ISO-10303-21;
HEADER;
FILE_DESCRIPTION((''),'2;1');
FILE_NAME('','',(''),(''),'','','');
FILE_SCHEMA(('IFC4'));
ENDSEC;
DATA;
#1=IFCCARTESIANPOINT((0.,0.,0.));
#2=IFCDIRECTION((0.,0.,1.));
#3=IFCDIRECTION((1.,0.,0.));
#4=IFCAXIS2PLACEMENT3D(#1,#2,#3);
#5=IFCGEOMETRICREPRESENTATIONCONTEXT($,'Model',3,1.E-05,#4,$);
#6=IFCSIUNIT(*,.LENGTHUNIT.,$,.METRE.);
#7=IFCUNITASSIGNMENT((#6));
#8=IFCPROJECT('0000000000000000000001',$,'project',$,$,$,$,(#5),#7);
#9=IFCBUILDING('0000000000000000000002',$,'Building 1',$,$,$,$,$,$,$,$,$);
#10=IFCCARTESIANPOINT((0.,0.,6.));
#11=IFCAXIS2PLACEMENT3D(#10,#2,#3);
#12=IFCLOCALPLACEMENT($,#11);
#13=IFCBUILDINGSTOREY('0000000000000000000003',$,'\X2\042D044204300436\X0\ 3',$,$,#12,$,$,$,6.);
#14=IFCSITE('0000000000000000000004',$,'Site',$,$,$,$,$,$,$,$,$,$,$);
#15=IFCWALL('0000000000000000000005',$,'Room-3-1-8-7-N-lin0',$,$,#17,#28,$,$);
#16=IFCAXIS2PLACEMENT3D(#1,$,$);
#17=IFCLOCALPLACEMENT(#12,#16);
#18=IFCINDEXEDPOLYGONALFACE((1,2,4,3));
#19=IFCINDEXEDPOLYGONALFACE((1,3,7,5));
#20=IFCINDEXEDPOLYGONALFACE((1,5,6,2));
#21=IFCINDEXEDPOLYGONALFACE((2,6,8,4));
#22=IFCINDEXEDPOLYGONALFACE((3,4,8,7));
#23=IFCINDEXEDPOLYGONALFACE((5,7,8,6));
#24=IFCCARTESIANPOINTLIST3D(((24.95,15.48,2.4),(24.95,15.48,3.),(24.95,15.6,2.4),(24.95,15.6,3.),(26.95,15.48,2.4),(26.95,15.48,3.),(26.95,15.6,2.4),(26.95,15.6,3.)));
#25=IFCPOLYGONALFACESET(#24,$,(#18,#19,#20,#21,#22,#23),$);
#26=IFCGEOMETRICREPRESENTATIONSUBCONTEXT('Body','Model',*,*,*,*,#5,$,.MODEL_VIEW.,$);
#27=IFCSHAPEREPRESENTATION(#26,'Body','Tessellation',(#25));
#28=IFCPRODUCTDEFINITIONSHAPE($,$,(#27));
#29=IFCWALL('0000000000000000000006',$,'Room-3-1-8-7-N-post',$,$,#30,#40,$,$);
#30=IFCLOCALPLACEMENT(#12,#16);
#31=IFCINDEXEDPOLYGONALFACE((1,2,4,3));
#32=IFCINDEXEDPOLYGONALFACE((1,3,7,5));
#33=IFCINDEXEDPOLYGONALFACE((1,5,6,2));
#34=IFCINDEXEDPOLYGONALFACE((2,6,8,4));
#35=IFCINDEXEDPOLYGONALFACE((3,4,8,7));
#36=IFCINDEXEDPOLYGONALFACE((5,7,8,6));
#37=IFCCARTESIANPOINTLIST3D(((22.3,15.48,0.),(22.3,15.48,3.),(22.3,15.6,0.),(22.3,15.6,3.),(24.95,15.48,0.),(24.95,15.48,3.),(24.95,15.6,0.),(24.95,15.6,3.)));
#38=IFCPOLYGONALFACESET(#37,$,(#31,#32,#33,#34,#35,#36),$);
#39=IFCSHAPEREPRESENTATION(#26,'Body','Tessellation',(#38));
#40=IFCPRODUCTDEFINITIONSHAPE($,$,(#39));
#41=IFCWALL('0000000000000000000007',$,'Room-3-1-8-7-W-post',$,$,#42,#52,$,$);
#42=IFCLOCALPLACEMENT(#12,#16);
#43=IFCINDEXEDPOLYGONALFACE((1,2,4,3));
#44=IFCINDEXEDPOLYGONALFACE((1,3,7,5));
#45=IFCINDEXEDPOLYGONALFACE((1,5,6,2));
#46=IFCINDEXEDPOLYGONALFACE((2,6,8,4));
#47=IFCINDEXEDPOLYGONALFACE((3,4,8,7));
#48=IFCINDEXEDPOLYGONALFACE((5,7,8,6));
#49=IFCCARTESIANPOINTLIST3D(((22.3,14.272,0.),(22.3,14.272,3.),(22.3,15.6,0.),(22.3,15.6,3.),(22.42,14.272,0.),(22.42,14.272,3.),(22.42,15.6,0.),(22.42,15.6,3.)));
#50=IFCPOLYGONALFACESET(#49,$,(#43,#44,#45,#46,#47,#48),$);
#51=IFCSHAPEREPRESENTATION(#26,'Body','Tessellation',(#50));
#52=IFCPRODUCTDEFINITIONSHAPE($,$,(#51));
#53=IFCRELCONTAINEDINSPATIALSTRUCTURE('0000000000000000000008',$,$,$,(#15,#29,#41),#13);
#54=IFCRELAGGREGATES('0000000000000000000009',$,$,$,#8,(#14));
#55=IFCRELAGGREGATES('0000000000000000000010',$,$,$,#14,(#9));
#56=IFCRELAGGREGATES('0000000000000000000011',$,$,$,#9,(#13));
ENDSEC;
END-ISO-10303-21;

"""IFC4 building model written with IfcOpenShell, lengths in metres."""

from ifc_helpers import new_model, si_unit, frame, origin_with_axes, place, context, subcontext, project, spatial, indexed_curve, outline, extrude, element, save


model = new_model("IFC4")

# Units and contexts
model_context = context("Model", 3, precision=1e-05, world=origin_with_axes())
body_context = subcontext(model_context, "Body", "Model", "MODEL_VIEW")
ifc_project = project(units=[si_unit("LENGTHUNIT", "METRE")], contexts=[model_context])

# Site, building, storey
site = spatial("IfcSite", under=ifc_project, Name="Site")
building = spatial("IfcBuilding", under=site, Name="Building 1")
storey_placement = place(None, frame((0.0, 0.0, 6.0), z_axis=(0.0, 0.0, 1.0), x_axis=(1.0, 0.0, 0.0)))
storey = spatial("IfcBuildingStorey", under=building, at=storey_placement, Name="Этаж 3", Elevation=6.0)

# Walls
wall_1_placement = place(storey_placement, frame((26.95, 15.6, 2.4), z_axis=(0.0, 0.0, 1.0), x_axis=(-1.0, 0.0, 0.0)))
element("IfcWall", 1, at=wall_1_placement, inside=storey, Name="Room-3-1-8-7-N-lin0", context=body_context, shape_type="SweptSolid", body=[
    extrude(outline(indexed_curve([(0.0, 0.0), (0.0, 0.12), (2.0, 0.12), (2.0, 0.0), (0.0, 0.0)], self_intersect=False)), origin_with_axes(), (0.0, 0.0, 1.0), 0.6),
])
wall_2_placement = place(storey_placement, frame((24.95, 15.6, 0.0), z_axis=(0.0, 0.0, 1.0), x_axis=(-1.0, 0.0, 0.0)))
element("IfcWall", 2, at=wall_2_placement, inside=storey, Name="Room-3-1-8-7-N-post", context=body_context, shape_type="SweptSolid", body=[
    extrude(outline(indexed_curve([(0.0, 0.0), (0.0, 0.12), (2.65, 0.12), (2.65, 0.0), (0.0, 0.0)], self_intersect=False)), origin_with_axes(), (0.0, 0.0, 1.0), 3.0),
])
wall_3_placement = place(storey_placement, frame((22.3, 15.6, 0.0), z_axis=(0.0, 0.0, 1.0), x_axis=(0.0, -1.0, 0.0)))
element("IfcWall", 3, at=wall_3_placement, inside=storey, Name="Room-3-1-8-7-W-post", context=body_context, shape_type="SweptSolid", body=[
    extrude(outline(indexed_curve([(0.0, 0.0), (0.0, 0.12), (1.328, 0.12), (1.328, 0.0), (0.0, 0.0)], self_intersect=False)), origin_with_axes(), (0.0, 0.0, 1.0), 3.0),
])

save(model, "model.ifc")
